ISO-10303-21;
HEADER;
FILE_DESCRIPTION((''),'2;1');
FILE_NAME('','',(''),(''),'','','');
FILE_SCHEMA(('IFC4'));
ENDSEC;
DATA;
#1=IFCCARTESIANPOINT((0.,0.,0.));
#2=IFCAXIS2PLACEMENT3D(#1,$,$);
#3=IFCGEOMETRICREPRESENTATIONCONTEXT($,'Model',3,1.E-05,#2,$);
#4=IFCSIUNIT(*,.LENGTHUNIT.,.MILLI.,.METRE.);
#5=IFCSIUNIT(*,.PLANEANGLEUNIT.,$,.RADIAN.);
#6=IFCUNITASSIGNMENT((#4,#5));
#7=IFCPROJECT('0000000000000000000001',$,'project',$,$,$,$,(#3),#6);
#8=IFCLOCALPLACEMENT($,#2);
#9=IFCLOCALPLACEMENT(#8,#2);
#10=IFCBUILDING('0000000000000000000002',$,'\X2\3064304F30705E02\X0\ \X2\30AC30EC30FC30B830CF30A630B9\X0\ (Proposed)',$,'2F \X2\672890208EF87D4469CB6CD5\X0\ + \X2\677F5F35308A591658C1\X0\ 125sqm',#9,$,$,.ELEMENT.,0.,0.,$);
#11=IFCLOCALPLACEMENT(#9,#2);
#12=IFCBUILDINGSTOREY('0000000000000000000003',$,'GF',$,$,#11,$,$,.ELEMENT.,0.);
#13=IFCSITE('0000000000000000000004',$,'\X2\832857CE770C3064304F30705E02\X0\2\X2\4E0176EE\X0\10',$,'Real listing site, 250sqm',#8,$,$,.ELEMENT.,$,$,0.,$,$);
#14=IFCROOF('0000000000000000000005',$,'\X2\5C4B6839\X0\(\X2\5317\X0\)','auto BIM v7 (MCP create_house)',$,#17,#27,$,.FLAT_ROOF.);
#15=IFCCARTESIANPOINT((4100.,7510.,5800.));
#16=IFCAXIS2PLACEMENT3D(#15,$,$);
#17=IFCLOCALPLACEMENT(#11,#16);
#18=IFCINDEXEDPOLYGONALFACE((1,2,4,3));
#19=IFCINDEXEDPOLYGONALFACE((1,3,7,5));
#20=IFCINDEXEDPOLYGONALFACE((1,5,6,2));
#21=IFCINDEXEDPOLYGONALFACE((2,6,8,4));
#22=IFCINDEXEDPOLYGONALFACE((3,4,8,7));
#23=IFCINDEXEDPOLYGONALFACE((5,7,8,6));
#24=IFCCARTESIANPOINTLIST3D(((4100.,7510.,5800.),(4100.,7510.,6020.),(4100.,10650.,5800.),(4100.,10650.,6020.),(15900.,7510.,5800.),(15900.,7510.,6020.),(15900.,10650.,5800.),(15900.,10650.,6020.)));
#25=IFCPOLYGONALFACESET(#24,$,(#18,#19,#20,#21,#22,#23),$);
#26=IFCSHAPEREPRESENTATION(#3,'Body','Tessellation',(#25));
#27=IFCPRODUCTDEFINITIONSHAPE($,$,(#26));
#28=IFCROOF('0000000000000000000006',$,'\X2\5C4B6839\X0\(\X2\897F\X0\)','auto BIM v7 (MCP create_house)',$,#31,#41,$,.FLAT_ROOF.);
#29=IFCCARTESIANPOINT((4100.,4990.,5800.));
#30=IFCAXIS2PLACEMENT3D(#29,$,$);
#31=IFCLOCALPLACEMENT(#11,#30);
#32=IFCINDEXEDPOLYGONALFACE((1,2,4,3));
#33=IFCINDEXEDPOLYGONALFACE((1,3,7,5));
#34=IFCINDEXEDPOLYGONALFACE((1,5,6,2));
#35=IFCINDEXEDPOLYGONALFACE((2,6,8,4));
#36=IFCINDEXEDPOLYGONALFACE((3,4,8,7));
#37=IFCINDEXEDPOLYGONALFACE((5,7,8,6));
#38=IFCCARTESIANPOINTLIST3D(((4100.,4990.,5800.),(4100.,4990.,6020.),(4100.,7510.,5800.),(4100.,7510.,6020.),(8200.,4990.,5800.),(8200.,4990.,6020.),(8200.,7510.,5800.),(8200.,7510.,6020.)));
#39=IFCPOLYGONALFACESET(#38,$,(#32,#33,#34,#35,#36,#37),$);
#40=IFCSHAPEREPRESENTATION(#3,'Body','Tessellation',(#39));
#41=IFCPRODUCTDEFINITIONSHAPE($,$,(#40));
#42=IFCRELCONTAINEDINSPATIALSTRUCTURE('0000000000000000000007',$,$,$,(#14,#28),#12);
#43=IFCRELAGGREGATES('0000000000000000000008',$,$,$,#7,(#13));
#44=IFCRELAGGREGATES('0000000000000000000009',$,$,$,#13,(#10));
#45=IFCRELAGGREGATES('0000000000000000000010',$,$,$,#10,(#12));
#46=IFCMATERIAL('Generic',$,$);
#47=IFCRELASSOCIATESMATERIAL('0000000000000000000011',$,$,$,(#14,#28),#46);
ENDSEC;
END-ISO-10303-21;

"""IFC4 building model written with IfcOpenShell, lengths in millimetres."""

from ifc_helpers import new_model, si_unit, frame, frame_2d, origin, place, context, project, spatial, rectangle, extrude, material, element, save


model = new_model("IFC4")

# Units and contexts
model_context = context("Model", 3, precision=1e-05, world=origin())
ifc_project = project(units=[si_unit("LENGTHUNIT", "METRE", prefix="MILLI"), si_unit("PLANEANGLEUNIT", "RADIAN")], contexts=[model_context])

# Site, building, storey
site_placement = place(None, origin())
site = spatial("IfcSite", under=ifc_project, at=site_placement, Name="茨城県つくば市2丁目10", ObjectType="Real listing site, 250sqm", CompositionType="ELEMENT", RefElevation=0.0)
building_placement = place(site_placement, origin())
building = spatial("IfcBuilding", under=site, at=building_placement, Name="つくば市 ガレージハウス (Proposed)", ObjectType="2F 木造軸組構法 + 板張り外壁 125sqm", CompositionType="ELEMENT", ElevationOfRefHeight=0.0, ElevationOfTerrain=0.0)
storey_placement = place(building_placement, origin())
storey = spatial("IfcBuildingStorey", under=building, at=storey_placement, Name="GF", CompositionType="ELEMENT", Elevation=0.0)

# Shared definitions
ifc_material = material(Name="Generic")

# Roofs
roof_1_placement = place(storey_placement, frame((4100.0, 7510.0, 5800.0)))
element("IfcRoof", 1, at=roof_1_placement, inside=storey, material=ifc_material, Name="屋根(北)", Description="auto BIM v7 (MCP create_house)", PredefinedType="FLAT_ROOF", context=model_context, shape_type="SweptSolid", body=[
    extrude(rectangle(XDim=11800.0, YDim=3140.0, at=frame_2d((5900.0, 1570.0))), frame((4100.0, 7510.0, 5800.0)), (0.0, 0.0, 1.0), 220.0),
])
roof_2_placement = place(storey_placement, frame((4100.0, 4990.0, 5800.0)))
element("IfcRoof", 2, at=roof_2_placement, inside=storey, material=ifc_material, Name="屋根(西)", Description="auto BIM v7 (MCP create_house)", PredefinedType="FLAT_ROOF", context=model_context, shape_type="SweptSolid", body=[
    extrude(rectangle(XDim=4100.0, YDim=2520.0, at=frame_2d((2050.0, 1260.0))), frame((4100.0, 4990.0, 5800.0)), (0.0, 0.0, 1.0), 220.0),
])

save(model, "model.ifc")
